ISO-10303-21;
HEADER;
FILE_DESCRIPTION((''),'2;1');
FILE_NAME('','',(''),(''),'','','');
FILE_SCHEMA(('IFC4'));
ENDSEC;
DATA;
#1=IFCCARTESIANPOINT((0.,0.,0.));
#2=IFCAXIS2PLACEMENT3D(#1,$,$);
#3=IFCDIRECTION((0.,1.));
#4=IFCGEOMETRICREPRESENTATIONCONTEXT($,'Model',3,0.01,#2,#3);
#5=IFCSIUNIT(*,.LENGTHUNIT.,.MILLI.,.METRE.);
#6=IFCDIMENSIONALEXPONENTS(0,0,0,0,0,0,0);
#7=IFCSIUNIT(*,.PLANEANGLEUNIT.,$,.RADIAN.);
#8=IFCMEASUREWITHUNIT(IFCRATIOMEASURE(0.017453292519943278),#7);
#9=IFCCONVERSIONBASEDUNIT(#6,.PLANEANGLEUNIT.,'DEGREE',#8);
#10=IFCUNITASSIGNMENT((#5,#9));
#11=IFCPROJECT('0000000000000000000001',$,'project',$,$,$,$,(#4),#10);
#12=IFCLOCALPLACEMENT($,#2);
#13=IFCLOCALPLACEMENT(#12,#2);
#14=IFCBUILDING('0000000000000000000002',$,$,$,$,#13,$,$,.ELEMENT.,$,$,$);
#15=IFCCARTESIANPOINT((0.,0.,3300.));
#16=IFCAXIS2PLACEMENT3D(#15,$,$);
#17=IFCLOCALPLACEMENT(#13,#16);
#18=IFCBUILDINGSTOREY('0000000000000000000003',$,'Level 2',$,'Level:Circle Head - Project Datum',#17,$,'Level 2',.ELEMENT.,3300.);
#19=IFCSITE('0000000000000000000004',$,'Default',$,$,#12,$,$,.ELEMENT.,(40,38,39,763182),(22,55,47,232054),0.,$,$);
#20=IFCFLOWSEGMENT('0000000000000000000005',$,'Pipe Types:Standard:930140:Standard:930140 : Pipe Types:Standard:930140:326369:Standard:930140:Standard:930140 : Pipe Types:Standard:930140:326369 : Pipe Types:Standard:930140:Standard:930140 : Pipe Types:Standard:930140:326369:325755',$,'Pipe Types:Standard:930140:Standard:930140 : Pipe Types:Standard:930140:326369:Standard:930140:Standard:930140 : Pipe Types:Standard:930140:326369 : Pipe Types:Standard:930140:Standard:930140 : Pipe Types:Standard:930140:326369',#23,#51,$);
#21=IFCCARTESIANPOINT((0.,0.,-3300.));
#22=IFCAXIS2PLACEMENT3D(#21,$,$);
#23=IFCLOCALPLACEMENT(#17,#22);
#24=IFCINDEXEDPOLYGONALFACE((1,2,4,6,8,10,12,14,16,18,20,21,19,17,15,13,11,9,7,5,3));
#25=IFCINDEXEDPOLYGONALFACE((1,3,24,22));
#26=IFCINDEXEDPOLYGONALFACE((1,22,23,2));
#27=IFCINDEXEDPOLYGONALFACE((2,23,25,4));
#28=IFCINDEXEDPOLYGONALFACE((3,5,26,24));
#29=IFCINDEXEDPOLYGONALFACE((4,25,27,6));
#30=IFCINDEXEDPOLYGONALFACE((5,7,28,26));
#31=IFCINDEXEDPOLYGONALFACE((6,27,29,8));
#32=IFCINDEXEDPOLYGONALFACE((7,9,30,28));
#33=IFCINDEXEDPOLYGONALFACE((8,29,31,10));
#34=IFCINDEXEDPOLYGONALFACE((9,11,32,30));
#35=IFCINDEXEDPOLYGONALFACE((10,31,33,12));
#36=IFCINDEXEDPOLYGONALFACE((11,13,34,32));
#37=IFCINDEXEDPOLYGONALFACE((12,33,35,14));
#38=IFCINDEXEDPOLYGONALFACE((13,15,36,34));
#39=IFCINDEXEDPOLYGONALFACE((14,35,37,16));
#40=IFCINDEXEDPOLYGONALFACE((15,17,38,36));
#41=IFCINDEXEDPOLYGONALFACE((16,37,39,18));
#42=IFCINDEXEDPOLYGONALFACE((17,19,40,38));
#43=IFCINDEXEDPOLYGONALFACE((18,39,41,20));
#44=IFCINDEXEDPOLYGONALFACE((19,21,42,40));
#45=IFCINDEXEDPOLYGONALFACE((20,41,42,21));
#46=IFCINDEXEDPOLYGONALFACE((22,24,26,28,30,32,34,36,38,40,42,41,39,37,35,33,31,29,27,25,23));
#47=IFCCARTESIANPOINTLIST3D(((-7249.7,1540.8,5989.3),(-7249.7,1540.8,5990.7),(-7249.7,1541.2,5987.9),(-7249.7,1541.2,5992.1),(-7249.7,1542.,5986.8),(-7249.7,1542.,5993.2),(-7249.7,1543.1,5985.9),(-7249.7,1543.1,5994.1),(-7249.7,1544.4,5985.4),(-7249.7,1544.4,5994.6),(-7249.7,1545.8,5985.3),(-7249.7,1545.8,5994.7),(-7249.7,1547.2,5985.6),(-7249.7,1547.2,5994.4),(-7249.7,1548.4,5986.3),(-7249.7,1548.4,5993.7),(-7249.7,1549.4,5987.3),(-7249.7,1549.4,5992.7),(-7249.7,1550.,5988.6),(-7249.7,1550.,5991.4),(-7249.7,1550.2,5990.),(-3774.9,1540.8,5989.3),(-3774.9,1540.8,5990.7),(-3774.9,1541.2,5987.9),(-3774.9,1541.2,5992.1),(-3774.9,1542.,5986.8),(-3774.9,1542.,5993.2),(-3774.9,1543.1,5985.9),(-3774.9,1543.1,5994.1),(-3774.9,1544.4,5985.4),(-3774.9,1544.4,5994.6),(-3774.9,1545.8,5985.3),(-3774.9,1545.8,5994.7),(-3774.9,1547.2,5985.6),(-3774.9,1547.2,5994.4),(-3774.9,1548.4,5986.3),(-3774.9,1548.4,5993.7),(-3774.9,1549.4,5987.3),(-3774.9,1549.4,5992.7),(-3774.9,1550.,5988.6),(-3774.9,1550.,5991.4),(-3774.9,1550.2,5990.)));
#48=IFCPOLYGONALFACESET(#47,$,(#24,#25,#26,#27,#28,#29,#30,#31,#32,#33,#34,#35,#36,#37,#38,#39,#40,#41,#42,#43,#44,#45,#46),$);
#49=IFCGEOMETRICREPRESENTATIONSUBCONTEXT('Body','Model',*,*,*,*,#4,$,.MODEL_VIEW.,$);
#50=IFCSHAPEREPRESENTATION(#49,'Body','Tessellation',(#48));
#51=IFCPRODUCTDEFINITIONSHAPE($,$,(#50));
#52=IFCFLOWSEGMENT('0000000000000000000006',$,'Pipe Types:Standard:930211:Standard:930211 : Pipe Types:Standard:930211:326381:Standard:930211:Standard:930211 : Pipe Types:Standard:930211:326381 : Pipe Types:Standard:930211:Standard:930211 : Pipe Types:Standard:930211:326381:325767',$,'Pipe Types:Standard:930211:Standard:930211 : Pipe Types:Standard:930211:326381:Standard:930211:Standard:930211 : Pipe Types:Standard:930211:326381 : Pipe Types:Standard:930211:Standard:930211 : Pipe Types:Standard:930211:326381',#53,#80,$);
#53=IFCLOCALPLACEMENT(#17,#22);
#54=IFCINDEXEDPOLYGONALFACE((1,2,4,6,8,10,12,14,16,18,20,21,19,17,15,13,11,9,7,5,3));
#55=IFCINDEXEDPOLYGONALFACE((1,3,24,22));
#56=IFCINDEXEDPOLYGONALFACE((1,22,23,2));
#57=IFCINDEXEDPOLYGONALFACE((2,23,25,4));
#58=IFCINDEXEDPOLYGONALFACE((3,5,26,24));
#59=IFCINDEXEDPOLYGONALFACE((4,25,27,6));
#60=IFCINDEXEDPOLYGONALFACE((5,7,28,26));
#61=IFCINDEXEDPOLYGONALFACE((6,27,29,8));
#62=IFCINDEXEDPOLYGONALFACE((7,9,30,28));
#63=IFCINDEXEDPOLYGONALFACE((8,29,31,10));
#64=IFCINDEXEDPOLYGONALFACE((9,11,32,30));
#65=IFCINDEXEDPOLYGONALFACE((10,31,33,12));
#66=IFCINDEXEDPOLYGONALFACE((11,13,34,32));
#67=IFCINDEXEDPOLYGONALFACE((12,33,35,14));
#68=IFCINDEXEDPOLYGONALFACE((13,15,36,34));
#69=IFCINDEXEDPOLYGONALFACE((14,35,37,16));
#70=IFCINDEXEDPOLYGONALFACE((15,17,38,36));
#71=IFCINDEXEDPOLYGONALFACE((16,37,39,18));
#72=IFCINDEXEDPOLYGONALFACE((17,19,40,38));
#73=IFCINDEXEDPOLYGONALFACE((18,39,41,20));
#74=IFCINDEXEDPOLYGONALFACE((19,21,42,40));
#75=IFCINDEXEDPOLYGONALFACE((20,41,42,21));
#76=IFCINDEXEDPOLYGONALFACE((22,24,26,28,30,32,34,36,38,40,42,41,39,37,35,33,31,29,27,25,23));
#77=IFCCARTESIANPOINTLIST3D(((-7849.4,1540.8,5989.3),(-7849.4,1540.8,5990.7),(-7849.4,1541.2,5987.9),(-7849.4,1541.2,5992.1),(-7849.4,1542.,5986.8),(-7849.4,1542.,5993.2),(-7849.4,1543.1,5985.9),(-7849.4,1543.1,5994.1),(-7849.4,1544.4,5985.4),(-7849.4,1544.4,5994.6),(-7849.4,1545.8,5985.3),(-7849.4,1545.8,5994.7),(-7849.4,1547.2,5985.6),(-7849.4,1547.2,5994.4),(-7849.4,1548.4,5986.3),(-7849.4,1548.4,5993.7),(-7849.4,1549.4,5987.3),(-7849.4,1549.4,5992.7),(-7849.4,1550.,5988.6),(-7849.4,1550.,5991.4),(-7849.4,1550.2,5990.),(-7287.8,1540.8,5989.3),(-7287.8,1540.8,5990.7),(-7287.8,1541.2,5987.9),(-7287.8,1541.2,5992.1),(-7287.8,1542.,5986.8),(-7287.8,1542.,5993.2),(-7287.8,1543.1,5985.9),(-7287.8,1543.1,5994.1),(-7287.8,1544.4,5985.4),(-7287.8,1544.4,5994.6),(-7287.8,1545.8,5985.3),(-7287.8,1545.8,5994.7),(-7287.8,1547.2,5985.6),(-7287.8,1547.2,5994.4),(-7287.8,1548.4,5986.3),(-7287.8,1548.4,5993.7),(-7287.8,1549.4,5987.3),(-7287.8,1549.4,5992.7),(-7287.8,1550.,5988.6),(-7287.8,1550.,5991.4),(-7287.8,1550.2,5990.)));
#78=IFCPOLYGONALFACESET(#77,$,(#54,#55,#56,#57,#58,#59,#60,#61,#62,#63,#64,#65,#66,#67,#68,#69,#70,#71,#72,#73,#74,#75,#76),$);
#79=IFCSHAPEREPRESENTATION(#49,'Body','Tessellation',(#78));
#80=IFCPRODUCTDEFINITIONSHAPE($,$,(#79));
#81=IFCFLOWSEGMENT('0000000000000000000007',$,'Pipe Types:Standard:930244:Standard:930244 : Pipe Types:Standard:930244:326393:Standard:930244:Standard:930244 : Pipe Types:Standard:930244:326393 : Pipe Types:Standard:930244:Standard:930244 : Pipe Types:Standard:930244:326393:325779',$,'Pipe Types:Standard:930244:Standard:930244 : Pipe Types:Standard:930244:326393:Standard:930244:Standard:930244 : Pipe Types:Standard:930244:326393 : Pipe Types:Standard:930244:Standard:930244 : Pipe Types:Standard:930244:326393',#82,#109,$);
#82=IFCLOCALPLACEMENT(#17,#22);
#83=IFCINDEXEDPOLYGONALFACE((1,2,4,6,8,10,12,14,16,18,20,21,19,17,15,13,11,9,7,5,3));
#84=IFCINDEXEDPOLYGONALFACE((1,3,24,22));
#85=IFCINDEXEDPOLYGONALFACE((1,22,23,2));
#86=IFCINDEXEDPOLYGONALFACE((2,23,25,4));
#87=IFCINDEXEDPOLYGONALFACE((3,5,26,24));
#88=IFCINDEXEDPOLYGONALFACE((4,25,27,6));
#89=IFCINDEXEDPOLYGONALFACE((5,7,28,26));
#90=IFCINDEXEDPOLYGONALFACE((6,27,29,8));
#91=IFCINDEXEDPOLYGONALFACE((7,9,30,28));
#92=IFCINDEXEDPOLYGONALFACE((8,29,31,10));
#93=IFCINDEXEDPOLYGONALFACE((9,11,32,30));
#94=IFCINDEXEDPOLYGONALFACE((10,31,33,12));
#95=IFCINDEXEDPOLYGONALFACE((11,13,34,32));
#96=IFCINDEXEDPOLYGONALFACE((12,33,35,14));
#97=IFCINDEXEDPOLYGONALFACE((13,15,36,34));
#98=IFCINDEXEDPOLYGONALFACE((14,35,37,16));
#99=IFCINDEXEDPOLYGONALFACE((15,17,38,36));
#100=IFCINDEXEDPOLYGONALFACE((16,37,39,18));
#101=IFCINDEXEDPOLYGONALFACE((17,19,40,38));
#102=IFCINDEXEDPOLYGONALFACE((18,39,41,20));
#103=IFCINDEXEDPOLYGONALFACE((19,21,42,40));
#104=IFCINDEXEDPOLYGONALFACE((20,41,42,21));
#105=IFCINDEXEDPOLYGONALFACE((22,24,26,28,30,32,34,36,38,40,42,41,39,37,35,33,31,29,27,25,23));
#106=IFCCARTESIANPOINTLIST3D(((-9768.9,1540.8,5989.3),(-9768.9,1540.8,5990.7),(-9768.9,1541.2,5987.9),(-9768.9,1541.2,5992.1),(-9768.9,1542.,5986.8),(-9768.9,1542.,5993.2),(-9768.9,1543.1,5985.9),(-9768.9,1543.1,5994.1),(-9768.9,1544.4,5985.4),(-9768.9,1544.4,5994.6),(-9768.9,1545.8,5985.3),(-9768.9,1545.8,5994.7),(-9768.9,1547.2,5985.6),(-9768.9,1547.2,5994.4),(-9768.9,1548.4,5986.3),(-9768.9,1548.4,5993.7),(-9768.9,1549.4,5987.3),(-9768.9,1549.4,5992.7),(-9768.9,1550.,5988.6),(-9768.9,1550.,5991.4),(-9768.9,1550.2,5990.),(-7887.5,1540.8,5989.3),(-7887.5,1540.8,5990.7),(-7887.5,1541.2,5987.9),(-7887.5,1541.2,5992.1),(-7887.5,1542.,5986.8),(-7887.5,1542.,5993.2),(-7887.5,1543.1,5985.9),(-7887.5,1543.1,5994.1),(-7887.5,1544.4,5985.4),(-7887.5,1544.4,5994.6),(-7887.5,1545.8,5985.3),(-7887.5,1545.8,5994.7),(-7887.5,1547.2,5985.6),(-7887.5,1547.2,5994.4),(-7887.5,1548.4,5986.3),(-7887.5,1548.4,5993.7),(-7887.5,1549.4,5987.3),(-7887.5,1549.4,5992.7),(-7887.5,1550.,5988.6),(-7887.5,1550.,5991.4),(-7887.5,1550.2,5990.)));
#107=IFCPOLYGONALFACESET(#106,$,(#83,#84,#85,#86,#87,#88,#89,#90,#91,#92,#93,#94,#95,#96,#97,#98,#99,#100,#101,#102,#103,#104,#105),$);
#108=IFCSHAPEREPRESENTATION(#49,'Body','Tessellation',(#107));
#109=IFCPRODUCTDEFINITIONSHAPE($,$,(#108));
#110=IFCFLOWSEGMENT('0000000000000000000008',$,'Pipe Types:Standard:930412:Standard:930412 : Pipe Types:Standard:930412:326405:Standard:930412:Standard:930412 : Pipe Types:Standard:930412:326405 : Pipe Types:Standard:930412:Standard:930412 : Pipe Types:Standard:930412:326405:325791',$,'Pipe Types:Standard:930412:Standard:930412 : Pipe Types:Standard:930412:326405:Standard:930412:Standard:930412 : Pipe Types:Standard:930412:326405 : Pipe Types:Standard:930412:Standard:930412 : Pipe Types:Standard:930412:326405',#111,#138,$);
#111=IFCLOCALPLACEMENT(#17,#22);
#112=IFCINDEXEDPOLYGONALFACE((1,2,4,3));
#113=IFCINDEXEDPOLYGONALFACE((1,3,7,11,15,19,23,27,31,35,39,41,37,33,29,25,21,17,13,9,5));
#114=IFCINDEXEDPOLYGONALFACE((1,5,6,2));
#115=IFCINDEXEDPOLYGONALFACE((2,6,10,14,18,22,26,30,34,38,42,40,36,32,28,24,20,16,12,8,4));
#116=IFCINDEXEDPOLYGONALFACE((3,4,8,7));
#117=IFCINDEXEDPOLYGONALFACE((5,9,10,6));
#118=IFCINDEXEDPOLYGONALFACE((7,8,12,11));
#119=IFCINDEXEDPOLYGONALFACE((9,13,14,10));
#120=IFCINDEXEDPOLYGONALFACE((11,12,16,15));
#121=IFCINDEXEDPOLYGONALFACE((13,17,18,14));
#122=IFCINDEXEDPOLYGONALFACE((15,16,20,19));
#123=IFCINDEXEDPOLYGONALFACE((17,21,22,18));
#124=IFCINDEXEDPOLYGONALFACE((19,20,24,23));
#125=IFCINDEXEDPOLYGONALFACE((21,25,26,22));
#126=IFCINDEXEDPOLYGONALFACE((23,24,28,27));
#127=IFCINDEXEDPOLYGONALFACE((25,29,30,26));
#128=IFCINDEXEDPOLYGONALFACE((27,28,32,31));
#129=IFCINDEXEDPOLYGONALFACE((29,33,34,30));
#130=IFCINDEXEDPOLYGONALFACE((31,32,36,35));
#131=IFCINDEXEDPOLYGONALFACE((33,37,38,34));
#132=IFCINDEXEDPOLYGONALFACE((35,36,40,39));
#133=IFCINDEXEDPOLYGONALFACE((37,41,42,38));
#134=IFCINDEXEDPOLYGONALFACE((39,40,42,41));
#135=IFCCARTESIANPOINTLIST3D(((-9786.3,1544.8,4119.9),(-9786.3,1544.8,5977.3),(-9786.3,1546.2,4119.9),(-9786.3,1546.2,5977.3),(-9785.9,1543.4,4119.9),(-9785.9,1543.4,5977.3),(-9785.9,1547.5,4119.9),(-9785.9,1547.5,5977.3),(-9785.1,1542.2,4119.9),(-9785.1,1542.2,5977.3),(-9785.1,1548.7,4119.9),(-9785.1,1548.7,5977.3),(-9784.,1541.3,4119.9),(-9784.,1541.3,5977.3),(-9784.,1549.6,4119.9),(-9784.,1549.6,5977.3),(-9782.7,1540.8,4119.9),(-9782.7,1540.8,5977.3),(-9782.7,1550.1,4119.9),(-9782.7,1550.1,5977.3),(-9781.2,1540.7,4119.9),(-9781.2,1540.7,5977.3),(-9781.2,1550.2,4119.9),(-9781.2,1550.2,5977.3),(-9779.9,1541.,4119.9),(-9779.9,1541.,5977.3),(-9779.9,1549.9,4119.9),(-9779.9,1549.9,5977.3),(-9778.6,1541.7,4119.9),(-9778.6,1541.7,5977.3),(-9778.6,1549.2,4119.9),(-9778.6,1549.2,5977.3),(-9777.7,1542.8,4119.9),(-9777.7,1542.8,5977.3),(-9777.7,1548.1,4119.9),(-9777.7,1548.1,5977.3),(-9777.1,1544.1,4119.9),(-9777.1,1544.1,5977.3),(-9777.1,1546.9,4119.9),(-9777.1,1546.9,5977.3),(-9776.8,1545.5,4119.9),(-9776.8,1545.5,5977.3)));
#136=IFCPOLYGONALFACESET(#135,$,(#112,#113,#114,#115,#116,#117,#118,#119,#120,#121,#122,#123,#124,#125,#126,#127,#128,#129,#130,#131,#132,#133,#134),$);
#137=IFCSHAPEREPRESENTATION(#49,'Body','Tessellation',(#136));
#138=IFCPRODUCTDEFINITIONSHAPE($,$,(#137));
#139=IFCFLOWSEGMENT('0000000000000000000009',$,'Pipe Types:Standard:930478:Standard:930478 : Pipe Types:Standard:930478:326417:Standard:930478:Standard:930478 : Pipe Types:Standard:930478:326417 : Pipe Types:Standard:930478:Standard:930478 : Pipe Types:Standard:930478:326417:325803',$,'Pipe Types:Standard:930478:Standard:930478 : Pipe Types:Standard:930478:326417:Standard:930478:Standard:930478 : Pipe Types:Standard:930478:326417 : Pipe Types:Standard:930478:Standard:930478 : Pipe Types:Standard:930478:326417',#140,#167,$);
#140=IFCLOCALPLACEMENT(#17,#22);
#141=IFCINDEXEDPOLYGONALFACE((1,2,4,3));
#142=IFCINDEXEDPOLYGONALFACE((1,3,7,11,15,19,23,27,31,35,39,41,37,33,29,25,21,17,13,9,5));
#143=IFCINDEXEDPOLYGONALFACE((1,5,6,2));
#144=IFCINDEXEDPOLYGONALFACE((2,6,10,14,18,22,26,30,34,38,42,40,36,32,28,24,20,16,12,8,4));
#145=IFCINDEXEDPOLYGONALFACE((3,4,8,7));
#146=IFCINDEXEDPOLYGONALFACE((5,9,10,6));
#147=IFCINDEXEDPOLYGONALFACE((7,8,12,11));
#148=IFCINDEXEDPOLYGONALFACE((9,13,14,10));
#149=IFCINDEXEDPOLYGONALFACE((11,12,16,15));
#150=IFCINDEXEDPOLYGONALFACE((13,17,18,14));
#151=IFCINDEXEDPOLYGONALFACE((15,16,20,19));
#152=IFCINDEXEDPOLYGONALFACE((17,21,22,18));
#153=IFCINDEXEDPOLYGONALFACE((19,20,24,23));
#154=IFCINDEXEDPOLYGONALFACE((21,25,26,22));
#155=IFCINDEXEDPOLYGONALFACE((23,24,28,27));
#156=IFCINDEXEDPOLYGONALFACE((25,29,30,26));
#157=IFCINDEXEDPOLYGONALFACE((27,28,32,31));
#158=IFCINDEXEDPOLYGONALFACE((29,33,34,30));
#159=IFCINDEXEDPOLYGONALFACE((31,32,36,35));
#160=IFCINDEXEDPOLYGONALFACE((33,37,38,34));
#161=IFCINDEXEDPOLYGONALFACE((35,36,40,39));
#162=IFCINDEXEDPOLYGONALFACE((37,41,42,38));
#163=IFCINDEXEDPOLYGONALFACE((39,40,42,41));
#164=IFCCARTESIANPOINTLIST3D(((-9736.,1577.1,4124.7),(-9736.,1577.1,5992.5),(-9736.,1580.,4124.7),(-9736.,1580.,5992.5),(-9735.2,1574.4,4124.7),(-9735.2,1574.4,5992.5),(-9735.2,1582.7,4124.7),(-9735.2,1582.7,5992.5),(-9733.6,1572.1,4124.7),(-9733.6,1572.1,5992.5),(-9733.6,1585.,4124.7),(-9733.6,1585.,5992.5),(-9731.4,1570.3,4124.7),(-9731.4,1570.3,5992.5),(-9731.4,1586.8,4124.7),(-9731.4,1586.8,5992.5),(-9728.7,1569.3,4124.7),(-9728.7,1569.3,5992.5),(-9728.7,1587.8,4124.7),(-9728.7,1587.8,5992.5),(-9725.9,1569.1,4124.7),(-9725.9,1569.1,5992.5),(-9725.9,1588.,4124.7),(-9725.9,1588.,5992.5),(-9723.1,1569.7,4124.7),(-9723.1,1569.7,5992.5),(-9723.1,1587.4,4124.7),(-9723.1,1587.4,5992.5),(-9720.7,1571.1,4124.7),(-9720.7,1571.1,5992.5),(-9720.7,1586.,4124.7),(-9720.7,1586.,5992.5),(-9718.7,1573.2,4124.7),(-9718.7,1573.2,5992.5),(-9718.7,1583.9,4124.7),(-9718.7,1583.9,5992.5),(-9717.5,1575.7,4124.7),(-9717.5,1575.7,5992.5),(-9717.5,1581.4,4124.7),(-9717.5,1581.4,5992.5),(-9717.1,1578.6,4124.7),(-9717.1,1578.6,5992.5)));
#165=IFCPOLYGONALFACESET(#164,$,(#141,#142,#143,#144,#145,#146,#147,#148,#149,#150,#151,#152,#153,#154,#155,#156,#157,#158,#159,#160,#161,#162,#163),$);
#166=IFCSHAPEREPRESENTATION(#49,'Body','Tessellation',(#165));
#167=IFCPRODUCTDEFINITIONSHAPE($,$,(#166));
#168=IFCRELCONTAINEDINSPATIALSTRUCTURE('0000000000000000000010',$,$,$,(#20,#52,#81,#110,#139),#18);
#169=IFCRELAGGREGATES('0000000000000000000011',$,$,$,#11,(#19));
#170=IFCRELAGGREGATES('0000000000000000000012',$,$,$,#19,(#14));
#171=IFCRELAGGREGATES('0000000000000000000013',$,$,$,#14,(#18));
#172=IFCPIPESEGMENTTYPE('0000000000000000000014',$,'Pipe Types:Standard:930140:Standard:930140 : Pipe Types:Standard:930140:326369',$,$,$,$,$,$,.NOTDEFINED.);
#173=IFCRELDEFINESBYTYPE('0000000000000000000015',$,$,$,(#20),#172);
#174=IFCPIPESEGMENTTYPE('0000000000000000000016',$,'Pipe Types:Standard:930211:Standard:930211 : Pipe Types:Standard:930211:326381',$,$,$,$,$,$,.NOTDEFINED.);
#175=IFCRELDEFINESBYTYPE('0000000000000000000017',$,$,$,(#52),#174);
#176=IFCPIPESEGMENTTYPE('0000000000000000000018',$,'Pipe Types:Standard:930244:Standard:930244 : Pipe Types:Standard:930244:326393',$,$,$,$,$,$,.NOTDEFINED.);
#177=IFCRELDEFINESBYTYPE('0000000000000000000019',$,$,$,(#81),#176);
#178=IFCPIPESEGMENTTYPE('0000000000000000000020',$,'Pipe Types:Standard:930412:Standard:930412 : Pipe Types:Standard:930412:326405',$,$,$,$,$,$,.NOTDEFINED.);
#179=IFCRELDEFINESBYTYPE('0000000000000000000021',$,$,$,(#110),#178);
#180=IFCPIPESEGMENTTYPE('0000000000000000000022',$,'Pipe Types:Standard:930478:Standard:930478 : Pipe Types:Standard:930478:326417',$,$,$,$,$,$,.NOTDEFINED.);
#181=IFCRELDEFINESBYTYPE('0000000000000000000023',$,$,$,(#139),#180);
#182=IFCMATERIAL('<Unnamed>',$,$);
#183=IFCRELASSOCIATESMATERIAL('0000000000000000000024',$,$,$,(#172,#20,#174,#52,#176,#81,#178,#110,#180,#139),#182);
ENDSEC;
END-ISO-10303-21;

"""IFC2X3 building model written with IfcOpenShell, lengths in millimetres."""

from ifc_helpers import new_model, entity, si_unit, converted_unit, direction, frame, origin, origin_2d_with_axis, place, context, subcontext, project, spatial, circle, extrude, source, transform, mapped, material, type_object, type_shapes, element, save


model = new_model("IFC2X3")

# Units and contexts
model_context = context("Model", 3, precision=0.01, world=origin(), true_north=direction((0.0, 1.0)))
body_context = subcontext(model_context, "Body", "Model", "MODEL_VIEW")
ifc_project = project(units=[si_unit("LENGTHUNIT", "METRE", prefix="MILLI"), converted_unit("PLANEANGLEUNIT", "DEGREE", entity("IfcRatioMeasure", 0.017453292519943278), si_unit("PLANEANGLEUNIT", "RADIAN"), dimensions=[0, 0, 0, 0, 0, 0, 0])], contexts=[model_context])

# Site, building, storey
site_placement = place(None, origin())
site = spatial("IfcSite", under=ifc_project, at=site_placement, Name="Default", CompositionType="ELEMENT", RefLatitude=(40, 38, 39, 763182), RefLongitude=(22, 55, 47, 232054), RefElevation=0.0)
building_placement = place(site_placement, origin())
building = spatial("IfcBuilding", under=site, at=building_placement, CompositionType="ELEMENT")
storey_placement = place(building_placement, frame((0.0, 0.0, 3300.0)))
storey = spatial("IfcBuildingStorey", under=building, at=storey_placement, Name="Level 2", ObjectType="Level:Circle Head - Project Datum", LongName="Level 2", CompositionType="ELEMENT", Elevation=3300.0)

# Flow segments
ifc_material_1 = material(Name="<Unnamed>")
pipe_segment_type_1 = type_object("IfcPipeSegmentType", Name="Pipe Types:Standard:930140:Standard:930140 : Pipe Types:Standard:930140:326369", PredefinedType="NOTDEFINED", material=ifc_material_1)
shared_shape_1 = source(origin(), body_context, "Body", "SweptSolid", [
    extrude(circle(Radius=4.8, at=origin_2d_with_axis()), frame((-7249.7, 1545.5, 5990.0), z_axis=(1.0, 0.0, 0.0), x_axis=(0.0, 1.0, 0.0)), (0.0, 0.0, 1.0), 3474.8),
])
type_shapes(pipe_segment_type_1, [shared_shape_1])
flow_segment_1_placement = place(storey_placement, frame((0.0, 0.0, -3300.0)))
element("IfcFlowSegment", 1, at=flow_segment_1_placement, inside=storey, type_object=pipe_segment_type_1, material=ifc_material_1, Name="Pipe Types:Standard:930140:Standard:930140 : Pipe Types:Standard:930140:326369:Standard:930140:Standard:930140 : Pipe Types:Standard:930140:326369 : Pipe Types:Standard:930140:Standard:930140 : Pipe Types:Standard:930140:326369:325755", ObjectType="Pipe Types:Standard:930140:Standard:930140 : Pipe Types:Standard:930140:326369:Standard:930140:Standard:930140 : Pipe Types:Standard:930140:326369 : Pipe Types:Standard:930140:Standard:930140 : Pipe Types:Standard:930140:326369", context=body_context, shape_type="MappedRepresentation", body=[
    mapped(shared_shape_1, transform((0.0, 0.0, 0.0), scale=1.0)),
])
pipe_segment_type_2 = type_object("IfcPipeSegmentType", Name="Pipe Types:Standard:930211:Standard:930211 : Pipe Types:Standard:930211:326381", PredefinedType="NOTDEFINED", material=ifc_material_1)
shared_shape_2 = source(origin(), body_context, "Body", "SweptSolid", [
    extrude(circle(Radius=4.8, at=origin_2d_with_axis()), frame((-7849.4, 1545.5, 5990.0), z_axis=(1.0, 0.0, 0.0), x_axis=(0.0, 1.0, 0.0)), (0.0, 0.0, 1.0), 561.6),
])
type_shapes(pipe_segment_type_2, [shared_shape_2])
flow_segment_2_placement = place(storey_placement, frame((0.0, 0.0, -3300.0)))
element("IfcFlowSegment", 2, at=flow_segment_2_placement, inside=storey, type_object=pipe_segment_type_2, material=ifc_material_1, Name="Pipe Types:Standard:930211:Standard:930211 : Pipe Types:Standard:930211:326381:Standard:930211:Standard:930211 : Pipe Types:Standard:930211:326381 : Pipe Types:Standard:930211:Standard:930211 : Pipe Types:Standard:930211:326381:325767", ObjectType="Pipe Types:Standard:930211:Standard:930211 : Pipe Types:Standard:930211:326381:Standard:930211:Standard:930211 : Pipe Types:Standard:930211:326381 : Pipe Types:Standard:930211:Standard:930211 : Pipe Types:Standard:930211:326381", context=body_context, shape_type="MappedRepresentation", body=[
    mapped(shared_shape_2, transform((0.0, 0.0, 0.0), scale=1.0)),
])
pipe_segment_type_3 = type_object("IfcPipeSegmentType", Name="Pipe Types:Standard:930244:Standard:930244 : Pipe Types:Standard:930244:326393", PredefinedType="NOTDEFINED", material=ifc_material_1)
shared_shape_3 = source(origin(), body_context, "Body", "SweptSolid", [
    extrude(circle(Radius=4.8, at=origin_2d_with_axis()), frame((-9768.9, 1545.5, 5990.0), z_axis=(1.0, 0.0, 0.0), x_axis=(0.0, 1.0, 0.0)), (0.0, 0.0, 1.0), 1881.4),
])
type_shapes(pipe_segment_type_3, [shared_shape_3])
flow_segment_3_placement = place(storey_placement, frame((0.0, 0.0, -3300.0)))
element("IfcFlowSegment", 3, at=flow_segment_3_placement, inside=storey, type_object=pipe_segment_type_3, material=ifc_material_1, Name="Pipe Types:Standard:930244:Standard:930244 : Pipe Types:Standard:930244:326393:Standard:930244:Standard:930244 : Pipe Types:Standard:930244:326393 : Pipe Types:Standard:930244:Standard:930244 : Pipe Types:Standard:930244:326393:325779", ObjectType="Pipe Types:Standard:930244:Standard:930244 : Pipe Types:Standard:930244:326393:Standard:930244:Standard:930244 : Pipe Types:Standard:930244:326393 : Pipe Types:Standard:930244:Standard:930244 : Pipe Types:Standard:930244:326393", context=body_context, shape_type="MappedRepresentation", body=[
    mapped(shared_shape_3, transform((0.0, 0.0, 0.0), scale=1.0)),
])
pipe_segment_type_4 = type_object("IfcPipeSegmentType", Name="Pipe Types:Standard:930412:Standard:930412 : Pipe Types:Standard:930412:326405", PredefinedType="NOTDEFINED", material=ifc_material_1)
shared_shape_4 = source(origin(), body_context, "Body", "SweptSolid", [
    extrude(circle(Radius=4.8, at=origin_2d_with_axis()), frame((-9781.6, 1545.5, 4119.9)), (0.0, 0.0, 1.0), 1857.4),
])
type_shapes(pipe_segment_type_4, [shared_shape_4])
flow_segment_4_placement = place(storey_placement, frame((0.0, 0.0, -3300.0)))
element("IfcFlowSegment", 4, at=flow_segment_4_placement, inside=storey, type_object=pipe_segment_type_4, material=ifc_material_1, Name="Pipe Types:Standard:930412:Standard:930412 : Pipe Types:Standard:930412:326405:Standard:930412:Standard:930412 : Pipe Types:Standard:930412:326405 : Pipe Types:Standard:930412:Standard:930412 : Pipe Types:Standard:930412:326405:325791", ObjectType="Pipe Types:Standard:930412:Standard:930412 : Pipe Types:Standard:930412:326405:Standard:930412:Standard:930412 : Pipe Types:Standard:930412:326405 : Pipe Types:Standard:930412:Standard:930412 : Pipe Types:Standard:930412:326405", context=body_context, shape_type="MappedRepresentation", body=[
    mapped(shared_shape_4, transform((0.0, 0.0, 0.0), scale=1.0)),
])
pipe_segment_type_5 = type_object("IfcPipeSegmentType", Name="Pipe Types:Standard:930478:Standard:930478 : Pipe Types:Standard:930478:326417", PredefinedType="NOTDEFINED", material=ifc_material_1)
shared_shape_5 = source(origin(), body_context, "Body", "SweptSolid", [
    extrude(circle(Radius=9.5, at=origin_2d_with_axis()), frame((-9726.6, 1578.6, 4124.7)), (0.0, 0.0, 1.0), 1867.8),
])
type_shapes(pipe_segment_type_5, [shared_shape_5])
flow_segment_5_placement = place(storey_placement, frame((0.0, 0.0, -3300.0)))
element("IfcFlowSegment", 5, at=flow_segment_5_placement, inside=storey, type_object=pipe_segment_type_5, material=ifc_material_1, Name="Pipe Types:Standard:930478:Standard:930478 : Pipe Types:Standard:930478:326417:Standard:930478:Standard:930478 : Pipe Types:Standard:930478:326417 : Pipe Types:Standard:930478:Standard:930478 : Pipe Types:Standard:930478:326417:325803", ObjectType="Pipe Types:Standard:930478:Standard:930478 : Pipe Types:Standard:930478:326417:Standard:930478:Standard:930478 : Pipe Types:Standard:930478:326417 : Pipe Types:Standard:930478:Standard:930478 : Pipe Types:Standard:930478:326417", context=body_context, shape_type="MappedRepresentation", body=[
    mapped(shared_shape_5, transform((0.0, 0.0, 0.0), scale=1.0)),
])

save(model, "model.ifc")
